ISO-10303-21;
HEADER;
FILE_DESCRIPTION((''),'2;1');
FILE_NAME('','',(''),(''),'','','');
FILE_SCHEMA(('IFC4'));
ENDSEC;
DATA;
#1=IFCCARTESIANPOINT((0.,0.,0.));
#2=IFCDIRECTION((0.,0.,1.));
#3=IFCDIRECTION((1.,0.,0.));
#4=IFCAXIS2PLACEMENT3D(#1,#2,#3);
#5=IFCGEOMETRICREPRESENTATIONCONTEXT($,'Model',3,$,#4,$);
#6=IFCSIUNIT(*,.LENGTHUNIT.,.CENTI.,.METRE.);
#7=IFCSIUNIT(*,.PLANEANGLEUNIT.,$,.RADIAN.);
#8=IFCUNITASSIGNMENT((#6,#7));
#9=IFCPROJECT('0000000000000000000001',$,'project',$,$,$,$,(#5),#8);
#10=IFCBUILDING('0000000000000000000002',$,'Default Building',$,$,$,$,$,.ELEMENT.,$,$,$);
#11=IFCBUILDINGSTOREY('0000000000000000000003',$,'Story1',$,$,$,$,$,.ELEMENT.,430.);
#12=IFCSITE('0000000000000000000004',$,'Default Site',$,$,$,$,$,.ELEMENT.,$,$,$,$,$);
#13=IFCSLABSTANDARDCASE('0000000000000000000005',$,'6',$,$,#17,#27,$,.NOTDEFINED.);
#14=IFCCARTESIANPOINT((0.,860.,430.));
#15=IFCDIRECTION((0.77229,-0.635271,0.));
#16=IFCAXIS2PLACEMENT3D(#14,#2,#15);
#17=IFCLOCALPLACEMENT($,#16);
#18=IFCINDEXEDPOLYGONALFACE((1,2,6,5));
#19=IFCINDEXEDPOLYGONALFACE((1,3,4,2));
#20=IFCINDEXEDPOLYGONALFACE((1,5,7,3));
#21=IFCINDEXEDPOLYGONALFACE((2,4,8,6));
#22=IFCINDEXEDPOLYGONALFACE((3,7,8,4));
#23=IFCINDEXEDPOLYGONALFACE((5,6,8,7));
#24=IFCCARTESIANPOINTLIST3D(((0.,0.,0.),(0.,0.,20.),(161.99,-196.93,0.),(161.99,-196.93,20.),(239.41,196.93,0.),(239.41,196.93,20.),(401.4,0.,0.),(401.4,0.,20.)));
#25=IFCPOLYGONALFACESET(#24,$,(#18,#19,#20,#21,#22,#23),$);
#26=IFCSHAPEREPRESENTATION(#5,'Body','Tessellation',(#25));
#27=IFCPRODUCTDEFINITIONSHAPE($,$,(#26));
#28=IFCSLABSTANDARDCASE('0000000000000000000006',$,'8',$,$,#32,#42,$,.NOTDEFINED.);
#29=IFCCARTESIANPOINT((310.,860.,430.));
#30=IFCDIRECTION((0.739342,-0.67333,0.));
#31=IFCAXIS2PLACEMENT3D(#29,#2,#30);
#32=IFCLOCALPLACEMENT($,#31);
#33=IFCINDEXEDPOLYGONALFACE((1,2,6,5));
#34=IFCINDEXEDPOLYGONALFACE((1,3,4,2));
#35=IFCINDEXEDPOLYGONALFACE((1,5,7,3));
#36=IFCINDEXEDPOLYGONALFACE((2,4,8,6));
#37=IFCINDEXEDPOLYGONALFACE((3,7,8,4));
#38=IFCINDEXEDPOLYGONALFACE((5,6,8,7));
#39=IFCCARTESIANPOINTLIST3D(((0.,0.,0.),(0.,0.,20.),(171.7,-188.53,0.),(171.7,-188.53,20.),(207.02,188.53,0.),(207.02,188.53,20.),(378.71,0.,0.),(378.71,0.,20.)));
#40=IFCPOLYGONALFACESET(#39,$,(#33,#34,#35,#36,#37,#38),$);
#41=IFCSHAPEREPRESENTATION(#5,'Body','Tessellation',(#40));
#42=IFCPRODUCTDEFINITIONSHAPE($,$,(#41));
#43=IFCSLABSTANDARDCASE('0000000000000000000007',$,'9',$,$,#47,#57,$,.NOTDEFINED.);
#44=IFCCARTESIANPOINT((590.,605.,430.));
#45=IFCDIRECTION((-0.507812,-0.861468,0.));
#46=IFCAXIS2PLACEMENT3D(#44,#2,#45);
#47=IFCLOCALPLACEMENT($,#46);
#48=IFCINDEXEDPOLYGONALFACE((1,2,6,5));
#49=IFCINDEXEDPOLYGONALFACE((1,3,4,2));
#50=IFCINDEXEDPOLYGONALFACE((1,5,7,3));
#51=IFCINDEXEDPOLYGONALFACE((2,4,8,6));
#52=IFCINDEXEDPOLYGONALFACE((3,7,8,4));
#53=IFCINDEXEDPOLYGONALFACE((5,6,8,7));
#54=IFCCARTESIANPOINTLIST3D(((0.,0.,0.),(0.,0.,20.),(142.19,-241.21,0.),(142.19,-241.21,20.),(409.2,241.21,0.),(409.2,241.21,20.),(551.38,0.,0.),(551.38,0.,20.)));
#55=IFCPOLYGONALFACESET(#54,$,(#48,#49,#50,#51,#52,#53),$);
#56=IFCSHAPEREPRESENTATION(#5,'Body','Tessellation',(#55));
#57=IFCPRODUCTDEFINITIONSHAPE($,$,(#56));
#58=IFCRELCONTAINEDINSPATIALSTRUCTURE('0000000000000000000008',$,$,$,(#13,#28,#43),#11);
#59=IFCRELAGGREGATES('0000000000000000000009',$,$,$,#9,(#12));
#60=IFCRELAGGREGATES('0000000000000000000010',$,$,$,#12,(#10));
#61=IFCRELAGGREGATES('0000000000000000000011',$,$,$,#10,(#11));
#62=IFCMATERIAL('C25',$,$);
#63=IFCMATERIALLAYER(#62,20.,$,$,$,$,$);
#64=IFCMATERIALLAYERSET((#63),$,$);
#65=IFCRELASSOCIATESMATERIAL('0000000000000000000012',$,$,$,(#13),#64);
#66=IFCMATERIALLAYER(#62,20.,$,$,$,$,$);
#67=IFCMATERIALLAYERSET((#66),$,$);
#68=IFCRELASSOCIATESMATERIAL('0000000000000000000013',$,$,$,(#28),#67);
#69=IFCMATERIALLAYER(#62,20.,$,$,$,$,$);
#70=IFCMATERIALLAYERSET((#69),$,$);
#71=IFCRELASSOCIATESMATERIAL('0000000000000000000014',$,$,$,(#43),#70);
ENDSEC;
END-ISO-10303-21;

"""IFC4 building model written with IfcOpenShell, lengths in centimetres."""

from ifc_helpers import new_model, si_unit, frame, origin_with_axes, place, context, project, spatial, polyline, outline, extrude, material, layer, layer_set, layer_usage, element, save


model = new_model("IFC4")

# Units and contexts
model_context = context("Model", 3, world=origin_with_axes())
ifc_project = project(units=[si_unit("LENGTHUNIT", "METRE", prefix="CENTI"), si_unit("PLANEANGLEUNIT", "RADIAN")], contexts=[model_context])

# Site, building, storey
site = spatial("IfcSite", under=ifc_project, Name="Default Site", CompositionType="ELEMENT")
building = spatial("IfcBuilding", under=site, Name="Default Building", CompositionType="ELEMENT")
storey = spatial("IfcBuildingStorey", under=building, Name="Story1", CompositionType="ELEMENT", Elevation=430.0)

# Shared definitions
ifc_material = material(Name="C25")

# Slabs
ifc_layer_1 = layer(ifc_material, 20.0)
ifc_layer_set_1 = layer_set([ifc_layer_1])
ifc_layer_usage_1 = layer_usage(ifc_layer_set_1, "AXIS2", "POSITIVE", -20.0)
slab_1_placement = place(None, frame((0.0, 860.0, 430.0), z_axis=(0.0, 0.0, 1.0), x_axis=(0.77229, -0.635271, 0.0)))
element("IfcSlabStandardCase", 1, at=slab_1_placement, inside=storey, material=ifc_layer_usage_1, Name="6", PredefinedType="NOTDEFINED", context=model_context, shape_type="SweptSolid", body=[
    extrude(outline(polyline([(0.0, 0.0), (239.41, 196.93), (401.4, 0.0), (161.99, -196.93), (0.0, 0.0)])), origin_with_axes(), (0.0, 0.0, 1.0), 20.0),
])
ifc_layer_2 = layer(ifc_material, 20.0)
ifc_layer_set_2 = layer_set([ifc_layer_2])
ifc_layer_usage_2 = layer_usage(ifc_layer_set_2, "AXIS2", "POSITIVE", -20.0)
slab_2_placement = place(None, frame((310.0, 860.0, 430.0), z_axis=(0.0, 0.0, 1.0), x_axis=(0.739342, -0.67333, 0.0)))
element("IfcSlabStandardCase", 2, at=slab_2_placement, inside=storey, material=ifc_layer_usage_2, Name="8", PredefinedType="NOTDEFINED", context=model_context, shape_type="SweptSolid", body=[
    extrude(outline(polyline([(0.0, 0.0), (207.02, 188.53), (378.71, 0.0), (171.7, -188.53), (0.0, 0.0)])), origin_with_axes(), (0.0, 0.0, 1.0), 20.0),
])
ifc_layer_3 = layer(ifc_material, 20.0)
ifc_layer_set_3 = layer_set([ifc_layer_3])
ifc_layer_usage_3 = layer_usage(ifc_layer_set_3, "AXIS2", "POSITIVE", -20.0)
slab_3_placement = place(None, frame((590.0, 605.0, 430.0), z_axis=(0.0, 0.0, 1.0), x_axis=(-0.507812, -0.861468, 0.0)))
element("IfcSlabStandardCase", 3, at=slab_3_placement, inside=storey, material=ifc_layer_usage_3, Name="9", PredefinedType="NOTDEFINED", context=model_context, shape_type="SweptSolid", body=[
    extrude(outline(polyline([(0.0, 0.0), (409.2, 241.21), (551.38, 0.0), (142.19, -241.21), (0.0, 0.0)])), origin_with_axes(), (0.0, 0.0, 1.0), 20.0),
])

save(model, "model.ifc")
